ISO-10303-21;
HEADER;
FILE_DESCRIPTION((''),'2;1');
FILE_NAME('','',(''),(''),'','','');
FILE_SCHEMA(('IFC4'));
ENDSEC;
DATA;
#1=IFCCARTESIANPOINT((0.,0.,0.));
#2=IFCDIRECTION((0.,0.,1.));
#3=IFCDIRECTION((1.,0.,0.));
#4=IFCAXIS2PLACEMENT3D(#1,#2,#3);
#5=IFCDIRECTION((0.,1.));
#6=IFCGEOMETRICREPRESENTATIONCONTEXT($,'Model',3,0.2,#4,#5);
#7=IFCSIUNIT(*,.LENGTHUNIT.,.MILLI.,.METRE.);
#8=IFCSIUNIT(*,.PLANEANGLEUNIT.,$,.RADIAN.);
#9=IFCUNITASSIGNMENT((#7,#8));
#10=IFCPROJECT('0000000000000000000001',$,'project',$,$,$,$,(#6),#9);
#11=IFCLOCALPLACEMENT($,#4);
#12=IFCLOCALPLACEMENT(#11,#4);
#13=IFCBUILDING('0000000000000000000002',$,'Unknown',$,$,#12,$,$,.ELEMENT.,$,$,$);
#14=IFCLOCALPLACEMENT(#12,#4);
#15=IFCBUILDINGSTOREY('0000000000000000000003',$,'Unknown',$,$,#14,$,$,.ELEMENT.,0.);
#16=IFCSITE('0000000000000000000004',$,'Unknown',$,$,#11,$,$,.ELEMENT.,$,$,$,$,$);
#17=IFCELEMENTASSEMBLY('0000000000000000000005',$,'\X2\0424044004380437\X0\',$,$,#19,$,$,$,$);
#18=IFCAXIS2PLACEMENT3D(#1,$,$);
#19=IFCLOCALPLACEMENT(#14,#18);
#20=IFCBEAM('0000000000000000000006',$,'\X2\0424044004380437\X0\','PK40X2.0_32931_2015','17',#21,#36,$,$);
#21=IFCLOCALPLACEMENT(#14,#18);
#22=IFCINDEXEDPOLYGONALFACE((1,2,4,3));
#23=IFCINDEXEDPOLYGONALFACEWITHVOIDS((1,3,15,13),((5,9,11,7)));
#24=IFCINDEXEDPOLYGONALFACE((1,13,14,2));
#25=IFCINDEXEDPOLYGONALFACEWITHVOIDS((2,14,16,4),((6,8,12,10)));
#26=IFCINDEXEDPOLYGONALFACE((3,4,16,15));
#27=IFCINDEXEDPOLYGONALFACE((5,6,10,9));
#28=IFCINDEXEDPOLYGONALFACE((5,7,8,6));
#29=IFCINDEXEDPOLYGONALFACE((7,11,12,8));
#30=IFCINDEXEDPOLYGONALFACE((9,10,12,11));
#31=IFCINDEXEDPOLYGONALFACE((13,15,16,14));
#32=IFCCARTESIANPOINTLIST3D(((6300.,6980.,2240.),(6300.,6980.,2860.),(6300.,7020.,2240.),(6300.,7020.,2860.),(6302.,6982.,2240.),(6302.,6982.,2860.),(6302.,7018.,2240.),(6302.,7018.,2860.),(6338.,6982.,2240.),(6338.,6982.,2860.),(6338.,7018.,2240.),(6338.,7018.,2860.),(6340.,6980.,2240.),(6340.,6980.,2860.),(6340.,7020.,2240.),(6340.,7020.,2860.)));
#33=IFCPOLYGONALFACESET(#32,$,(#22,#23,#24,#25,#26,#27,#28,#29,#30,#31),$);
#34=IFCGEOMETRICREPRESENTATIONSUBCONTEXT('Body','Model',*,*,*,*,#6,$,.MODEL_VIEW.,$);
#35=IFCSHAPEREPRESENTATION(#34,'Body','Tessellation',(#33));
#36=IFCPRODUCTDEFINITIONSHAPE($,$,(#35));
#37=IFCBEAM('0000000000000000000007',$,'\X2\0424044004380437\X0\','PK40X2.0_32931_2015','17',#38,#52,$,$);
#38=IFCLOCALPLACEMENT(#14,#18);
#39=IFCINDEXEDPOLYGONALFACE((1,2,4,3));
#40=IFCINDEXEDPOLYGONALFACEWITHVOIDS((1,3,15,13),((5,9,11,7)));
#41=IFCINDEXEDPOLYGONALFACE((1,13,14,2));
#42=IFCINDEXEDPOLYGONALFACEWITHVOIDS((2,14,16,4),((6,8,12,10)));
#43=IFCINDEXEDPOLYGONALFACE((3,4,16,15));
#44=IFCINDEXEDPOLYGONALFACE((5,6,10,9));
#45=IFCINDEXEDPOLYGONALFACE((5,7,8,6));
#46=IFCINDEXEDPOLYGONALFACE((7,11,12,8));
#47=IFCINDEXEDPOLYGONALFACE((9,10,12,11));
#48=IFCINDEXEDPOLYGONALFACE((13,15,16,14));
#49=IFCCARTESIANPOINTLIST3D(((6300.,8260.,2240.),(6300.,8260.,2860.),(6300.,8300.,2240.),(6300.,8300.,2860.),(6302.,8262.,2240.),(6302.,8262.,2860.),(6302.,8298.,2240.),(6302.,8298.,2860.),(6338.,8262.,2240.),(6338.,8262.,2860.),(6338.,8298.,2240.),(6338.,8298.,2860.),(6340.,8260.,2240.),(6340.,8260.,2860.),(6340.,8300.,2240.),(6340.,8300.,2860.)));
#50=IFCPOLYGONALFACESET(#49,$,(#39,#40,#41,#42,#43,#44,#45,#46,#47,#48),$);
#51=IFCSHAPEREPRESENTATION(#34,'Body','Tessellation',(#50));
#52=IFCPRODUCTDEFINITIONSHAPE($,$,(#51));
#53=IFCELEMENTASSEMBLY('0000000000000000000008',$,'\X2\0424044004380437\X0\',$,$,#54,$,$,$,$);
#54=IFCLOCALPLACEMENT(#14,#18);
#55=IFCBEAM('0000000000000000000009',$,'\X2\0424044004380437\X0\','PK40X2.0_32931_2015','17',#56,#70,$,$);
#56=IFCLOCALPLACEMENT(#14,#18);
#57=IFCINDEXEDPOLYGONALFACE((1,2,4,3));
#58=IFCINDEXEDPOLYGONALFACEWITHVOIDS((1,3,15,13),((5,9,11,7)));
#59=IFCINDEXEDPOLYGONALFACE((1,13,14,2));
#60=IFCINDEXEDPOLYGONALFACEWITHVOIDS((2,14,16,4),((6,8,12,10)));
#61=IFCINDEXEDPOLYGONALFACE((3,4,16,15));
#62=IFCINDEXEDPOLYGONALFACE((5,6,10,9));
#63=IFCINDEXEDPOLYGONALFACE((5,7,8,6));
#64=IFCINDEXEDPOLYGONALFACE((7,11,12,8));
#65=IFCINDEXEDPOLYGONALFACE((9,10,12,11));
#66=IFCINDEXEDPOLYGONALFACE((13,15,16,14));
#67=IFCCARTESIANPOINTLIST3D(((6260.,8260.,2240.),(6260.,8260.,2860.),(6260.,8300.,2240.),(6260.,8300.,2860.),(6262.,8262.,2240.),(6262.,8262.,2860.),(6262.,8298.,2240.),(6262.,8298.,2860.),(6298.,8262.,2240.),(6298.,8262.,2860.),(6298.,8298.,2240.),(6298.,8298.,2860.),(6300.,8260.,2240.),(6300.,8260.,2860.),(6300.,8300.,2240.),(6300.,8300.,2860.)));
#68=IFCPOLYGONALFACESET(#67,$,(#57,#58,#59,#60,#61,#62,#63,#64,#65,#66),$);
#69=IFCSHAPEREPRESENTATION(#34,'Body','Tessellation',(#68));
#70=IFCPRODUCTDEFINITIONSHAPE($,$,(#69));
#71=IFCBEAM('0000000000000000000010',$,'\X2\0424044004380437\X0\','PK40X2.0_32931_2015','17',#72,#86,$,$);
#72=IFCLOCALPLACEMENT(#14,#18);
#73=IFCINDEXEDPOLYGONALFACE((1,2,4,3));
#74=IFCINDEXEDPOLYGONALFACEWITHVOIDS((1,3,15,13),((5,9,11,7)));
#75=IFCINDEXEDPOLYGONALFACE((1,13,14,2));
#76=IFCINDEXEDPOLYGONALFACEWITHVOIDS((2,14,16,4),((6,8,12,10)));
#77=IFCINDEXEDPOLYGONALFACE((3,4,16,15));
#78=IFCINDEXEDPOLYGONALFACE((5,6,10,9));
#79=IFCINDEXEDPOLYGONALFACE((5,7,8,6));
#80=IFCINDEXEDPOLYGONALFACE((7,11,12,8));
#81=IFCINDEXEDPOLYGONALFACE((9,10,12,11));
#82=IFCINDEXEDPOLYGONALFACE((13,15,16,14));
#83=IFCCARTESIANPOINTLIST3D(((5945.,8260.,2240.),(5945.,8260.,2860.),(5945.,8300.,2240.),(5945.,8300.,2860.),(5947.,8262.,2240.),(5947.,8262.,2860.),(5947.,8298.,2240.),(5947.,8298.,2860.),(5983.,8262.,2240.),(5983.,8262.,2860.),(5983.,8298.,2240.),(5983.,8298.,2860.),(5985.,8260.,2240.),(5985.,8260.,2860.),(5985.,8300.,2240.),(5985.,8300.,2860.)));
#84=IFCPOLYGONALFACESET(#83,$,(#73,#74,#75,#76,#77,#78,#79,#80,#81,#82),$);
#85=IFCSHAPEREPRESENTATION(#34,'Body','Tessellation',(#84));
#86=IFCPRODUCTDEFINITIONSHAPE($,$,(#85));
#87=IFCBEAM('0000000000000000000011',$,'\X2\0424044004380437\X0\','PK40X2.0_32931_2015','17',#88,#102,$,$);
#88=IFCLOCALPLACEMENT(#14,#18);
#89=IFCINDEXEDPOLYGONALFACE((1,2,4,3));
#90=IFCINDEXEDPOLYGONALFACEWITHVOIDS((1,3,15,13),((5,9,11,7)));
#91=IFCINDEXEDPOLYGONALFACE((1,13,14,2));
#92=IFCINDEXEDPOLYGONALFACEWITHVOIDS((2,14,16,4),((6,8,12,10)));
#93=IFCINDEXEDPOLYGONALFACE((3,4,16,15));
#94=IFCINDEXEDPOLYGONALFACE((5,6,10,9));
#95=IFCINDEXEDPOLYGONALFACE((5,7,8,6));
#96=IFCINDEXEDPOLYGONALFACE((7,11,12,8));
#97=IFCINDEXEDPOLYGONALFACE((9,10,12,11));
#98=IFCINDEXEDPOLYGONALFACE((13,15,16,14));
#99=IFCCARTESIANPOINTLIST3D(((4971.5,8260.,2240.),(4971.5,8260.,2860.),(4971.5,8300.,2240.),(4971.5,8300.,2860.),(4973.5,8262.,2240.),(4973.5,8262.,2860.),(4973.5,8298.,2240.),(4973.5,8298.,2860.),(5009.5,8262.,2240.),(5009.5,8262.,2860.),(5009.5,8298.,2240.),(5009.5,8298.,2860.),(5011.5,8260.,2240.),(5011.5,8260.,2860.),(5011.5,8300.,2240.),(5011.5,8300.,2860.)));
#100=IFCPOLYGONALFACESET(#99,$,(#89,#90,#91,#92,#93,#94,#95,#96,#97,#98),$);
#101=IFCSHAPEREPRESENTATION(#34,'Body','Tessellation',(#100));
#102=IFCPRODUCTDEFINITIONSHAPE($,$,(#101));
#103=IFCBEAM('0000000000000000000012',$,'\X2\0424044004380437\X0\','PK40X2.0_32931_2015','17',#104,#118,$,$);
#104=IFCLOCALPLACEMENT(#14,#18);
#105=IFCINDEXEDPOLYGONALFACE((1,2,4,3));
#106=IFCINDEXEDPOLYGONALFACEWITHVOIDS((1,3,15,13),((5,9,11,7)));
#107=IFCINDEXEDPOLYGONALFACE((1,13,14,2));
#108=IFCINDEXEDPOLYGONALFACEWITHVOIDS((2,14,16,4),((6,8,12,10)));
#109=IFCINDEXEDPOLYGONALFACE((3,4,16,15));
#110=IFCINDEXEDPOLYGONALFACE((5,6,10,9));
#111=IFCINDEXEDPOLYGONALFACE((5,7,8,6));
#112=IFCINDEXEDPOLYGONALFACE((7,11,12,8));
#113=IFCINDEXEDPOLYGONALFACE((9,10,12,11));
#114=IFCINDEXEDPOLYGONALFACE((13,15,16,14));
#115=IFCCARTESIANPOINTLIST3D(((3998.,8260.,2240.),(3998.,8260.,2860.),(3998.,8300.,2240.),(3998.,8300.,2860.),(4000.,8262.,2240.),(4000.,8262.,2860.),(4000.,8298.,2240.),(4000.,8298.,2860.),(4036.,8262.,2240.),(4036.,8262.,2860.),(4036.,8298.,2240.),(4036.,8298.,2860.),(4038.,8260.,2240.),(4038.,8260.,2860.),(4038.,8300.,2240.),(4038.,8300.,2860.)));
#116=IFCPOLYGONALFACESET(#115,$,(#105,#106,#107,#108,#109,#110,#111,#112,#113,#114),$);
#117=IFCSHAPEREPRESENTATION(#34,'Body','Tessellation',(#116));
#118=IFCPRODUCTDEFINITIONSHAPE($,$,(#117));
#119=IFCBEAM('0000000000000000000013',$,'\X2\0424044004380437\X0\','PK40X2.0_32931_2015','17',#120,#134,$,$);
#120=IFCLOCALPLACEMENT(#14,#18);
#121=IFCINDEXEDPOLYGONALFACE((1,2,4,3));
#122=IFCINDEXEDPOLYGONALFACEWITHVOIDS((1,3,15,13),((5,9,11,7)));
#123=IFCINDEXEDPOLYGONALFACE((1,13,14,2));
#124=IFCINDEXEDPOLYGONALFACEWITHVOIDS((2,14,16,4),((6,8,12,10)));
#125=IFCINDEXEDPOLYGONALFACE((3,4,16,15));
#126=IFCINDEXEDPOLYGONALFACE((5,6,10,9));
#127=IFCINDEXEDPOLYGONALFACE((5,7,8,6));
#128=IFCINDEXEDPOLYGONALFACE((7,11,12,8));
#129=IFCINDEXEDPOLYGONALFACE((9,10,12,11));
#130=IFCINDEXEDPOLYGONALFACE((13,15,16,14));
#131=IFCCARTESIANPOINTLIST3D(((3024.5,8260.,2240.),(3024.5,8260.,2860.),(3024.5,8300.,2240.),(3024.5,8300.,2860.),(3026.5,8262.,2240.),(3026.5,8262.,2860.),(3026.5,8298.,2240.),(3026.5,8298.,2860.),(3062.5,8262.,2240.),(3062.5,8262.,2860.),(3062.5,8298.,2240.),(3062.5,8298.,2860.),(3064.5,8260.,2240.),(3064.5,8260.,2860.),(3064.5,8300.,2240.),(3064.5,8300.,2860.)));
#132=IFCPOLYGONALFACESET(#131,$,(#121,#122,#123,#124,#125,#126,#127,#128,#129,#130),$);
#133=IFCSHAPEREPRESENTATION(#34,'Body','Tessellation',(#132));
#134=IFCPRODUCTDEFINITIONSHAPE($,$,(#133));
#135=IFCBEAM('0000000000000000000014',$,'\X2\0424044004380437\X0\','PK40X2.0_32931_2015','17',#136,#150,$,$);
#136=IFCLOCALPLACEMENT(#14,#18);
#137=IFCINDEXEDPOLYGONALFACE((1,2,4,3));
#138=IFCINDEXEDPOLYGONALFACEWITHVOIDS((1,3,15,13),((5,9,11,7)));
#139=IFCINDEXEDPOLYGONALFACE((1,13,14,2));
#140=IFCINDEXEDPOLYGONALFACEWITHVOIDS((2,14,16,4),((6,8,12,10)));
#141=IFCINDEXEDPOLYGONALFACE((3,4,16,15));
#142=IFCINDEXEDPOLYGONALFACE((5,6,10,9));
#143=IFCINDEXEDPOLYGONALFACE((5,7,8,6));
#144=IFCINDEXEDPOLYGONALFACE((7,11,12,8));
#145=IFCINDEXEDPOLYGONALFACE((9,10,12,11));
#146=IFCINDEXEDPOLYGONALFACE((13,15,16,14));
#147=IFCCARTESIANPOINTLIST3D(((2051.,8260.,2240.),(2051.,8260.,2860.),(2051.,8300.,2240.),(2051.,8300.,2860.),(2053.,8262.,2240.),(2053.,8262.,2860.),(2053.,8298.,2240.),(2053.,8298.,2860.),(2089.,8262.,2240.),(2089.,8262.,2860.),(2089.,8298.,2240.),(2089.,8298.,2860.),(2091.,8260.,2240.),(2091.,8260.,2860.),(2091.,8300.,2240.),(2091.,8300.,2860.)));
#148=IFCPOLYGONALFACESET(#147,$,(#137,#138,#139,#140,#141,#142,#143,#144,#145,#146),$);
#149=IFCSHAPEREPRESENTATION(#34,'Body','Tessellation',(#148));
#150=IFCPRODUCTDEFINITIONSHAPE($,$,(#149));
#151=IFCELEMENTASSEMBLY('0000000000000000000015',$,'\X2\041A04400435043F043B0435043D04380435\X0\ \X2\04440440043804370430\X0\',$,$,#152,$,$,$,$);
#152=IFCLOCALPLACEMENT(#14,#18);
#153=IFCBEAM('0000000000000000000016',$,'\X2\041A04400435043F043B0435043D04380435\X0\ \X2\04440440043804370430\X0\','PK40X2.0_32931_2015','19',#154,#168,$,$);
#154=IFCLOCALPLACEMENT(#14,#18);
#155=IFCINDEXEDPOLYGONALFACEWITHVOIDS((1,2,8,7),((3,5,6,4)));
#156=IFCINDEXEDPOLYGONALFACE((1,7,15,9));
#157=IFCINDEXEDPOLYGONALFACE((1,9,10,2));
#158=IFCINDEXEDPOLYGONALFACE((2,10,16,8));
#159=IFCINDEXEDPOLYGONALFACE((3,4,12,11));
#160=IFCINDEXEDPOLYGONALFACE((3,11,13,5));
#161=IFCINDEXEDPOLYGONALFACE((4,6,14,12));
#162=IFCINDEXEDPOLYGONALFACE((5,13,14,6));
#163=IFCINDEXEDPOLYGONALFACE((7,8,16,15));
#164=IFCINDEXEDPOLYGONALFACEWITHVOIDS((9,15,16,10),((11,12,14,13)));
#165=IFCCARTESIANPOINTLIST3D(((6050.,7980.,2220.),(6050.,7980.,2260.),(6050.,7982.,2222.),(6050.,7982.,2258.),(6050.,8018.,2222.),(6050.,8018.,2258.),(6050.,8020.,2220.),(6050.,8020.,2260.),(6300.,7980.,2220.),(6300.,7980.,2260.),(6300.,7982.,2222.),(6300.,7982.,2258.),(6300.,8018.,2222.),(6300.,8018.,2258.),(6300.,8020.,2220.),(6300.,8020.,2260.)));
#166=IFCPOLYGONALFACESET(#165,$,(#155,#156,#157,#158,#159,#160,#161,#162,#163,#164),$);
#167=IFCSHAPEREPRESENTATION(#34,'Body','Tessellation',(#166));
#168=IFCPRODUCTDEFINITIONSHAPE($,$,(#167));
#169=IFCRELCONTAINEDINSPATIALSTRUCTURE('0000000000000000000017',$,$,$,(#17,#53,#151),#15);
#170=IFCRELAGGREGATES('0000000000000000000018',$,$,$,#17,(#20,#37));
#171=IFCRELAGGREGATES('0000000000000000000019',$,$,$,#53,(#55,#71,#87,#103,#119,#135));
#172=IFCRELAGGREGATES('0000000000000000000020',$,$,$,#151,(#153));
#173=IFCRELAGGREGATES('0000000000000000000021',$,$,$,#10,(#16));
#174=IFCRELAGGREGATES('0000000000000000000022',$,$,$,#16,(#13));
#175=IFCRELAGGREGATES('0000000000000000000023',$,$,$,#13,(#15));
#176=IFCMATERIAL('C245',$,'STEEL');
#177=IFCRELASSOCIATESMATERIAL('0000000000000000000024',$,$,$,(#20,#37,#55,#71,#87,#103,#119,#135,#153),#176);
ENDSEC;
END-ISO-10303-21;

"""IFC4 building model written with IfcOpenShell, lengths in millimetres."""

from ifc_helpers import new_model, si_unit, direction, frame, origin_with_axes, place, context, subcontext, project, spatial, line, indexed_curve, outline, extrude, material, element, aggregate, save


model = new_model("IFC4")

# Units and contexts
model_context = context("Model", 3, precision=0.2, world=origin_with_axes(), true_north=direction((0.0, 1.0)))
body_context = subcontext(model_context, "Body", "Model", "MODEL_VIEW")
ifc_project = project(units=[si_unit("LENGTHUNIT", "METRE", prefix="MILLI"), si_unit("PLANEANGLEUNIT", "RADIAN")], contexts=[model_context])

# Site, building, storey
site_placement = place(None, origin_with_axes())
site = spatial("IfcSite", under=ifc_project, at=site_placement, Name="Unknown", CompositionType="ELEMENT")
building_placement = place(site_placement, origin_with_axes())
building = spatial("IfcBuilding", under=site, at=building_placement, Name="Unknown", CompositionType="ELEMENT")
storey_placement = place(building_placement, origin_with_axes())
storey = spatial("IfcBuildingStorey", under=building, at=storey_placement, Name="Unknown", CompositionType="ELEMENT", Elevation=0.0)

# Shared definitions
ifc_material_1 = material(Name="C245", Category="STEEL")

# Element assembly, beams
assembly_1_placement = place(storey_placement, frame((6320.0, -300.0, 2880.0), z_axis=(1.0, 0.0, 0.0), x_axis=(0.0, 1.0, 0.0)))
assembly_1 = element("IfcElementAssembly", 1, at=assembly_1_placement, inside=storey, Name="Фриз")
beam_1_placement = place(assembly_1_placement, frame((7300.0, -20.0, 0.0), z_axis=(1.0, 0.0, 0.0), x_axis=(0.0, -1.0, 0.0)))
beam_1 = element("IfcBeam", 2, at=beam_1_placement, material=ifc_material_1, Name="Фриз", Description="PK40X2.0_32931_2015", ObjectType="17", context=body_context, shape_type="SolidModel", body=[
    extrude(outline(indexed_curve([(-20.0, -20.0), (20.0, -20.0), (20.0, 20.0), (-20.0, 20.0)], segments=[line(1, 2, 3, 4, 1)]), holes=[indexed_curve([(-18.0, -18.0), (-18.0, 18.0), (18.0, 18.0), (18.0, -18.0)], segments=[line(1, 2, 3, 4, 1)])]), frame((0.0, 0.0, 0.0), z_axis=(-1.0, 0.0, 0.0), x_axis=(0.0, 0.0, 1.0)), (0.0, 0.0, -1.0), 620.0),
])
beam_2_placement = place(assembly_1_placement, frame((8580.0, -20.0, 0.0), z_axis=(1.0, 0.0, 0.0), x_axis=(0.0, -1.0, 0.0)))
beam_2 = element("IfcBeam", 3, at=beam_2_placement, material=ifc_material_1, Name="Фриз", Description="PK40X2.0_32931_2015", ObjectType="17", context=body_context, shape_type="SolidModel", body=[
    extrude(outline(indexed_curve([(-20.0, -20.0), (20.0, -20.0), (20.0, 20.0), (-20.0, 20.0)], segments=[line(1, 2, 3, 4, 1)]), holes=[indexed_curve([(-18.0, -18.0), (-18.0, 18.0), (18.0, 18.0), (18.0, -18.0)], segments=[line(1, 2, 3, 4, 1)])]), frame((0.0, 0.0, 0.0), z_axis=(-1.0, 0.0, 0.0), x_axis=(0.0, 0.0, 1.0)), (0.0, 0.0, -1.0), 620.0),
])
aggregate(assembly_1, [beam_1, beam_2])

# Element assembly, beams
assembly_2_placement = place(storey_placement, frame((-300.0, 8280.0, 2880.0), z_axis=(0.0, -1.0, 0.0), x_axis=(1.0, 0.0, 0.0)))
assembly_2 = element("IfcElementAssembly", 4, at=assembly_2_placement, inside=storey, Name="Фриз")
beam_3_placement = place(assembly_2_placement, frame((6580.0, -20.0, 0.0), z_axis=(0.0, 0.0, 1.0), x_axis=(0.0, -1.0, 0.0)))
beam_3 = element("IfcBeam", 5, at=beam_3_placement, material=ifc_material_1, Name="Фриз", Description="PK40X2.0_32931_2015", ObjectType="17", context=body_context, shape_type="SolidModel", body=[
    extrude(outline(indexed_curve([(-20.0, -20.0), (20.0, -20.0), (20.0, 20.0), (-20.0, 20.0)], segments=[line(1, 2, 3, 4, 1)]), holes=[indexed_curve([(-18.0, -18.0), (-18.0, 18.0), (18.0, 18.0), (18.0, -18.0)], segments=[line(1, 2, 3, 4, 1)])]), frame((0.0, 0.0, 0.0), z_axis=(-1.0, 0.0, 0.0), x_axis=(0.0, 0.0, 1.0)), (0.0, 0.0, -1.0), 620.0),
])
beam_4_placement = place(assembly_2_placement, frame((6265.0, -20.0, 0.0), z_axis=(0.0, 0.0, 1.0), x_axis=(0.0, -1.0, 0.0)))
beam_4 = element("IfcBeam", 6, at=beam_4_placement, material=ifc_material_1, Name="Фриз", Description="PK40X2.0_32931_2015", ObjectType="17", context=body_context, shape_type="SolidModel", body=[
    extrude(outline(indexed_curve([(-20.0, -20.0), (20.0, -20.0), (20.0, 20.0), (-20.0, 20.0)], segments=[line(1, 2, 3, 4, 1)]), holes=[indexed_curve([(-18.0, -18.0), (-18.0, 18.0), (18.0, 18.0), (18.0, -18.0)], segments=[line(1, 2, 3, 4, 1)])]), frame((0.0, 0.0, 0.0), z_axis=(-1.0, 0.0, 0.0), x_axis=(0.0, 0.0, 1.0)), (0.0, 0.0, -1.0), 620.0),
])
beam_5_placement = place(assembly_2_placement, frame((5291.5, -20.0, 0.0), z_axis=(0.0, 0.0, 1.0), x_axis=(0.0, -1.0, 0.0)))
beam_5 = element("IfcBeam", 7, at=beam_5_placement, material=ifc_material_1, Name="Фриз", Description="PK40X2.0_32931_2015", ObjectType="17", context=body_context, shape_type="SolidModel", body=[
    extrude(outline(indexed_curve([(-20.0, -20.0), (20.0, -20.0), (20.0, 20.0), (-20.0, 20.0)], segments=[line(1, 2, 3, 4, 1)]), holes=[indexed_curve([(-18.0, -18.0), (-18.0, 18.0), (18.0, 18.0), (18.0, -18.0)], segments=[line(1, 2, 3, 4, 1)])]), frame((0.0, 0.0, 0.0), z_axis=(-1.0, 0.0, 0.0), x_axis=(0.0, 0.0, 1.0)), (0.0, 0.0, -1.0), 620.0),
])
beam_6_placement = place(assembly_2_placement, frame((4318.0, -20.0, 0.0), z_axis=(0.0, 0.0, 1.0), x_axis=(0.0, -1.0, 0.0)))
beam_6 = element("IfcBeam", 8, at=beam_6_placement, material=ifc_material_1, Name="Фриз", Description="PK40X2.0_32931_2015", ObjectType="17", context=body_context, shape_type="SolidModel", body=[
    extrude(outline(indexed_curve([(-20.0, -20.0), (20.0, -20.0), (20.0, 20.0), (-20.0, 20.0)], segments=[line(1, 2, 3, 4, 1)]), holes=[indexed_curve([(-18.0, -18.0), (-18.0, 18.0), (18.0, 18.0), (18.0, -18.0)], segments=[line(1, 2, 3, 4, 1)])]), frame((0.0, 0.0, 0.0), z_axis=(-1.0, 0.0, 0.0), x_axis=(0.0, 0.0, 1.0)), (0.0, 0.0, -1.0), 620.0),
])
beam_7_placement = place(assembly_2_placement, frame((3344.5, -20.0, 0.0), z_axis=(0.0, 0.0, 1.0), x_axis=(0.0, -1.0, 0.0)))
beam_7 = element("IfcBeam", 9, at=beam_7_placement, material=ifc_material_1, Name="Фриз", Description="PK40X2.0_32931_2015", ObjectType="17", context=body_context, shape_type="SolidModel", body=[
    extrude(outline(indexed_curve([(-20.0, -20.0), (20.0, -20.0), (20.0, 20.0), (-20.0, 20.0)], segments=[line(1, 2, 3, 4, 1)]), holes=[indexed_curve([(-18.0, -18.0), (-18.0, 18.0), (18.0, 18.0), (18.0, -18.0)], segments=[line(1, 2, 3, 4, 1)])]), frame((0.0, 0.0, 0.0), z_axis=(-1.0, 0.0, 0.0), x_axis=(0.0, 0.0, 1.0)), (0.0, 0.0, -1.0), 620.0),
])
beam_8_placement = place(assembly_2_placement, frame((2371.0, -20.0, 0.0), z_axis=(0.0, 0.0, 1.0), x_axis=(0.0, -1.0, 0.0)))
beam_8 = element("IfcBeam", 10, at=beam_8_placement, material=ifc_material_1, Name="Фриз", Description="PK40X2.0_32931_2015", ObjectType="17", context=body_context, shape_type="SolidModel", body=[
    extrude(outline(indexed_curve([(-20.0, -20.0), (20.0, -20.0), (20.0, 20.0), (-20.0, 20.0)], segments=[line(1, 2, 3, 4, 1)]), holes=[indexed_curve([(-18.0, -18.0), (-18.0, 18.0), (18.0, 18.0), (18.0, -18.0)], segments=[line(1, 2, 3, 4, 1)])]), frame((0.0, 0.0, 0.0), z_axis=(-1.0, 0.0, 0.0), x_axis=(0.0, 0.0, 1.0)), (0.0, 0.0, -1.0), 620.0),
])
aggregate(assembly_2, [beam_3, beam_4, beam_5, beam_6, beam_7, beam_8])

# Element assembly, beam
assembly_3_placement = place(storey_placement, frame((6300.0, 8000.0, 2240.0), z_axis=(0.0, -1.0, 0.0), x_axis=(-1.0, 0.0, 0.0)))
assembly_3 = element("IfcElementAssembly", 11, at=assembly_3_placement, inside=storey, Name="Крепление фриза")
beam_9_placement = place(assembly_3_placement, origin_with_axes())
beam_9 = element("IfcBeam", 12, at=beam_9_placement, material=ifc_material_1, Name="Крепление фриза", Description="PK40X2.0_32931_2015", ObjectType="19", context=body_context, shape_type="SolidModel", body=[
    extrude(outline(indexed_curve([(-20.0, -20.0), (20.0, -20.0), (20.0, 20.0), (-20.0, 20.0)], segments=[line(1, 2, 3, 4, 1)]), holes=[indexed_curve([(-18.0, -18.0), (-18.0, 18.0), (18.0, 18.0), (18.0, -18.0)], segments=[line(1, 2, 3, 4, 1)])]), frame((0.0, 0.0, 0.0), z_axis=(-1.0, 0.0, 0.0), x_axis=(0.0, 0.0, 1.0)), (0.0, 0.0, -1.0), 250.0),
])
aggregate(assembly_3, [beam_9])

save(model, "model.ifc")
